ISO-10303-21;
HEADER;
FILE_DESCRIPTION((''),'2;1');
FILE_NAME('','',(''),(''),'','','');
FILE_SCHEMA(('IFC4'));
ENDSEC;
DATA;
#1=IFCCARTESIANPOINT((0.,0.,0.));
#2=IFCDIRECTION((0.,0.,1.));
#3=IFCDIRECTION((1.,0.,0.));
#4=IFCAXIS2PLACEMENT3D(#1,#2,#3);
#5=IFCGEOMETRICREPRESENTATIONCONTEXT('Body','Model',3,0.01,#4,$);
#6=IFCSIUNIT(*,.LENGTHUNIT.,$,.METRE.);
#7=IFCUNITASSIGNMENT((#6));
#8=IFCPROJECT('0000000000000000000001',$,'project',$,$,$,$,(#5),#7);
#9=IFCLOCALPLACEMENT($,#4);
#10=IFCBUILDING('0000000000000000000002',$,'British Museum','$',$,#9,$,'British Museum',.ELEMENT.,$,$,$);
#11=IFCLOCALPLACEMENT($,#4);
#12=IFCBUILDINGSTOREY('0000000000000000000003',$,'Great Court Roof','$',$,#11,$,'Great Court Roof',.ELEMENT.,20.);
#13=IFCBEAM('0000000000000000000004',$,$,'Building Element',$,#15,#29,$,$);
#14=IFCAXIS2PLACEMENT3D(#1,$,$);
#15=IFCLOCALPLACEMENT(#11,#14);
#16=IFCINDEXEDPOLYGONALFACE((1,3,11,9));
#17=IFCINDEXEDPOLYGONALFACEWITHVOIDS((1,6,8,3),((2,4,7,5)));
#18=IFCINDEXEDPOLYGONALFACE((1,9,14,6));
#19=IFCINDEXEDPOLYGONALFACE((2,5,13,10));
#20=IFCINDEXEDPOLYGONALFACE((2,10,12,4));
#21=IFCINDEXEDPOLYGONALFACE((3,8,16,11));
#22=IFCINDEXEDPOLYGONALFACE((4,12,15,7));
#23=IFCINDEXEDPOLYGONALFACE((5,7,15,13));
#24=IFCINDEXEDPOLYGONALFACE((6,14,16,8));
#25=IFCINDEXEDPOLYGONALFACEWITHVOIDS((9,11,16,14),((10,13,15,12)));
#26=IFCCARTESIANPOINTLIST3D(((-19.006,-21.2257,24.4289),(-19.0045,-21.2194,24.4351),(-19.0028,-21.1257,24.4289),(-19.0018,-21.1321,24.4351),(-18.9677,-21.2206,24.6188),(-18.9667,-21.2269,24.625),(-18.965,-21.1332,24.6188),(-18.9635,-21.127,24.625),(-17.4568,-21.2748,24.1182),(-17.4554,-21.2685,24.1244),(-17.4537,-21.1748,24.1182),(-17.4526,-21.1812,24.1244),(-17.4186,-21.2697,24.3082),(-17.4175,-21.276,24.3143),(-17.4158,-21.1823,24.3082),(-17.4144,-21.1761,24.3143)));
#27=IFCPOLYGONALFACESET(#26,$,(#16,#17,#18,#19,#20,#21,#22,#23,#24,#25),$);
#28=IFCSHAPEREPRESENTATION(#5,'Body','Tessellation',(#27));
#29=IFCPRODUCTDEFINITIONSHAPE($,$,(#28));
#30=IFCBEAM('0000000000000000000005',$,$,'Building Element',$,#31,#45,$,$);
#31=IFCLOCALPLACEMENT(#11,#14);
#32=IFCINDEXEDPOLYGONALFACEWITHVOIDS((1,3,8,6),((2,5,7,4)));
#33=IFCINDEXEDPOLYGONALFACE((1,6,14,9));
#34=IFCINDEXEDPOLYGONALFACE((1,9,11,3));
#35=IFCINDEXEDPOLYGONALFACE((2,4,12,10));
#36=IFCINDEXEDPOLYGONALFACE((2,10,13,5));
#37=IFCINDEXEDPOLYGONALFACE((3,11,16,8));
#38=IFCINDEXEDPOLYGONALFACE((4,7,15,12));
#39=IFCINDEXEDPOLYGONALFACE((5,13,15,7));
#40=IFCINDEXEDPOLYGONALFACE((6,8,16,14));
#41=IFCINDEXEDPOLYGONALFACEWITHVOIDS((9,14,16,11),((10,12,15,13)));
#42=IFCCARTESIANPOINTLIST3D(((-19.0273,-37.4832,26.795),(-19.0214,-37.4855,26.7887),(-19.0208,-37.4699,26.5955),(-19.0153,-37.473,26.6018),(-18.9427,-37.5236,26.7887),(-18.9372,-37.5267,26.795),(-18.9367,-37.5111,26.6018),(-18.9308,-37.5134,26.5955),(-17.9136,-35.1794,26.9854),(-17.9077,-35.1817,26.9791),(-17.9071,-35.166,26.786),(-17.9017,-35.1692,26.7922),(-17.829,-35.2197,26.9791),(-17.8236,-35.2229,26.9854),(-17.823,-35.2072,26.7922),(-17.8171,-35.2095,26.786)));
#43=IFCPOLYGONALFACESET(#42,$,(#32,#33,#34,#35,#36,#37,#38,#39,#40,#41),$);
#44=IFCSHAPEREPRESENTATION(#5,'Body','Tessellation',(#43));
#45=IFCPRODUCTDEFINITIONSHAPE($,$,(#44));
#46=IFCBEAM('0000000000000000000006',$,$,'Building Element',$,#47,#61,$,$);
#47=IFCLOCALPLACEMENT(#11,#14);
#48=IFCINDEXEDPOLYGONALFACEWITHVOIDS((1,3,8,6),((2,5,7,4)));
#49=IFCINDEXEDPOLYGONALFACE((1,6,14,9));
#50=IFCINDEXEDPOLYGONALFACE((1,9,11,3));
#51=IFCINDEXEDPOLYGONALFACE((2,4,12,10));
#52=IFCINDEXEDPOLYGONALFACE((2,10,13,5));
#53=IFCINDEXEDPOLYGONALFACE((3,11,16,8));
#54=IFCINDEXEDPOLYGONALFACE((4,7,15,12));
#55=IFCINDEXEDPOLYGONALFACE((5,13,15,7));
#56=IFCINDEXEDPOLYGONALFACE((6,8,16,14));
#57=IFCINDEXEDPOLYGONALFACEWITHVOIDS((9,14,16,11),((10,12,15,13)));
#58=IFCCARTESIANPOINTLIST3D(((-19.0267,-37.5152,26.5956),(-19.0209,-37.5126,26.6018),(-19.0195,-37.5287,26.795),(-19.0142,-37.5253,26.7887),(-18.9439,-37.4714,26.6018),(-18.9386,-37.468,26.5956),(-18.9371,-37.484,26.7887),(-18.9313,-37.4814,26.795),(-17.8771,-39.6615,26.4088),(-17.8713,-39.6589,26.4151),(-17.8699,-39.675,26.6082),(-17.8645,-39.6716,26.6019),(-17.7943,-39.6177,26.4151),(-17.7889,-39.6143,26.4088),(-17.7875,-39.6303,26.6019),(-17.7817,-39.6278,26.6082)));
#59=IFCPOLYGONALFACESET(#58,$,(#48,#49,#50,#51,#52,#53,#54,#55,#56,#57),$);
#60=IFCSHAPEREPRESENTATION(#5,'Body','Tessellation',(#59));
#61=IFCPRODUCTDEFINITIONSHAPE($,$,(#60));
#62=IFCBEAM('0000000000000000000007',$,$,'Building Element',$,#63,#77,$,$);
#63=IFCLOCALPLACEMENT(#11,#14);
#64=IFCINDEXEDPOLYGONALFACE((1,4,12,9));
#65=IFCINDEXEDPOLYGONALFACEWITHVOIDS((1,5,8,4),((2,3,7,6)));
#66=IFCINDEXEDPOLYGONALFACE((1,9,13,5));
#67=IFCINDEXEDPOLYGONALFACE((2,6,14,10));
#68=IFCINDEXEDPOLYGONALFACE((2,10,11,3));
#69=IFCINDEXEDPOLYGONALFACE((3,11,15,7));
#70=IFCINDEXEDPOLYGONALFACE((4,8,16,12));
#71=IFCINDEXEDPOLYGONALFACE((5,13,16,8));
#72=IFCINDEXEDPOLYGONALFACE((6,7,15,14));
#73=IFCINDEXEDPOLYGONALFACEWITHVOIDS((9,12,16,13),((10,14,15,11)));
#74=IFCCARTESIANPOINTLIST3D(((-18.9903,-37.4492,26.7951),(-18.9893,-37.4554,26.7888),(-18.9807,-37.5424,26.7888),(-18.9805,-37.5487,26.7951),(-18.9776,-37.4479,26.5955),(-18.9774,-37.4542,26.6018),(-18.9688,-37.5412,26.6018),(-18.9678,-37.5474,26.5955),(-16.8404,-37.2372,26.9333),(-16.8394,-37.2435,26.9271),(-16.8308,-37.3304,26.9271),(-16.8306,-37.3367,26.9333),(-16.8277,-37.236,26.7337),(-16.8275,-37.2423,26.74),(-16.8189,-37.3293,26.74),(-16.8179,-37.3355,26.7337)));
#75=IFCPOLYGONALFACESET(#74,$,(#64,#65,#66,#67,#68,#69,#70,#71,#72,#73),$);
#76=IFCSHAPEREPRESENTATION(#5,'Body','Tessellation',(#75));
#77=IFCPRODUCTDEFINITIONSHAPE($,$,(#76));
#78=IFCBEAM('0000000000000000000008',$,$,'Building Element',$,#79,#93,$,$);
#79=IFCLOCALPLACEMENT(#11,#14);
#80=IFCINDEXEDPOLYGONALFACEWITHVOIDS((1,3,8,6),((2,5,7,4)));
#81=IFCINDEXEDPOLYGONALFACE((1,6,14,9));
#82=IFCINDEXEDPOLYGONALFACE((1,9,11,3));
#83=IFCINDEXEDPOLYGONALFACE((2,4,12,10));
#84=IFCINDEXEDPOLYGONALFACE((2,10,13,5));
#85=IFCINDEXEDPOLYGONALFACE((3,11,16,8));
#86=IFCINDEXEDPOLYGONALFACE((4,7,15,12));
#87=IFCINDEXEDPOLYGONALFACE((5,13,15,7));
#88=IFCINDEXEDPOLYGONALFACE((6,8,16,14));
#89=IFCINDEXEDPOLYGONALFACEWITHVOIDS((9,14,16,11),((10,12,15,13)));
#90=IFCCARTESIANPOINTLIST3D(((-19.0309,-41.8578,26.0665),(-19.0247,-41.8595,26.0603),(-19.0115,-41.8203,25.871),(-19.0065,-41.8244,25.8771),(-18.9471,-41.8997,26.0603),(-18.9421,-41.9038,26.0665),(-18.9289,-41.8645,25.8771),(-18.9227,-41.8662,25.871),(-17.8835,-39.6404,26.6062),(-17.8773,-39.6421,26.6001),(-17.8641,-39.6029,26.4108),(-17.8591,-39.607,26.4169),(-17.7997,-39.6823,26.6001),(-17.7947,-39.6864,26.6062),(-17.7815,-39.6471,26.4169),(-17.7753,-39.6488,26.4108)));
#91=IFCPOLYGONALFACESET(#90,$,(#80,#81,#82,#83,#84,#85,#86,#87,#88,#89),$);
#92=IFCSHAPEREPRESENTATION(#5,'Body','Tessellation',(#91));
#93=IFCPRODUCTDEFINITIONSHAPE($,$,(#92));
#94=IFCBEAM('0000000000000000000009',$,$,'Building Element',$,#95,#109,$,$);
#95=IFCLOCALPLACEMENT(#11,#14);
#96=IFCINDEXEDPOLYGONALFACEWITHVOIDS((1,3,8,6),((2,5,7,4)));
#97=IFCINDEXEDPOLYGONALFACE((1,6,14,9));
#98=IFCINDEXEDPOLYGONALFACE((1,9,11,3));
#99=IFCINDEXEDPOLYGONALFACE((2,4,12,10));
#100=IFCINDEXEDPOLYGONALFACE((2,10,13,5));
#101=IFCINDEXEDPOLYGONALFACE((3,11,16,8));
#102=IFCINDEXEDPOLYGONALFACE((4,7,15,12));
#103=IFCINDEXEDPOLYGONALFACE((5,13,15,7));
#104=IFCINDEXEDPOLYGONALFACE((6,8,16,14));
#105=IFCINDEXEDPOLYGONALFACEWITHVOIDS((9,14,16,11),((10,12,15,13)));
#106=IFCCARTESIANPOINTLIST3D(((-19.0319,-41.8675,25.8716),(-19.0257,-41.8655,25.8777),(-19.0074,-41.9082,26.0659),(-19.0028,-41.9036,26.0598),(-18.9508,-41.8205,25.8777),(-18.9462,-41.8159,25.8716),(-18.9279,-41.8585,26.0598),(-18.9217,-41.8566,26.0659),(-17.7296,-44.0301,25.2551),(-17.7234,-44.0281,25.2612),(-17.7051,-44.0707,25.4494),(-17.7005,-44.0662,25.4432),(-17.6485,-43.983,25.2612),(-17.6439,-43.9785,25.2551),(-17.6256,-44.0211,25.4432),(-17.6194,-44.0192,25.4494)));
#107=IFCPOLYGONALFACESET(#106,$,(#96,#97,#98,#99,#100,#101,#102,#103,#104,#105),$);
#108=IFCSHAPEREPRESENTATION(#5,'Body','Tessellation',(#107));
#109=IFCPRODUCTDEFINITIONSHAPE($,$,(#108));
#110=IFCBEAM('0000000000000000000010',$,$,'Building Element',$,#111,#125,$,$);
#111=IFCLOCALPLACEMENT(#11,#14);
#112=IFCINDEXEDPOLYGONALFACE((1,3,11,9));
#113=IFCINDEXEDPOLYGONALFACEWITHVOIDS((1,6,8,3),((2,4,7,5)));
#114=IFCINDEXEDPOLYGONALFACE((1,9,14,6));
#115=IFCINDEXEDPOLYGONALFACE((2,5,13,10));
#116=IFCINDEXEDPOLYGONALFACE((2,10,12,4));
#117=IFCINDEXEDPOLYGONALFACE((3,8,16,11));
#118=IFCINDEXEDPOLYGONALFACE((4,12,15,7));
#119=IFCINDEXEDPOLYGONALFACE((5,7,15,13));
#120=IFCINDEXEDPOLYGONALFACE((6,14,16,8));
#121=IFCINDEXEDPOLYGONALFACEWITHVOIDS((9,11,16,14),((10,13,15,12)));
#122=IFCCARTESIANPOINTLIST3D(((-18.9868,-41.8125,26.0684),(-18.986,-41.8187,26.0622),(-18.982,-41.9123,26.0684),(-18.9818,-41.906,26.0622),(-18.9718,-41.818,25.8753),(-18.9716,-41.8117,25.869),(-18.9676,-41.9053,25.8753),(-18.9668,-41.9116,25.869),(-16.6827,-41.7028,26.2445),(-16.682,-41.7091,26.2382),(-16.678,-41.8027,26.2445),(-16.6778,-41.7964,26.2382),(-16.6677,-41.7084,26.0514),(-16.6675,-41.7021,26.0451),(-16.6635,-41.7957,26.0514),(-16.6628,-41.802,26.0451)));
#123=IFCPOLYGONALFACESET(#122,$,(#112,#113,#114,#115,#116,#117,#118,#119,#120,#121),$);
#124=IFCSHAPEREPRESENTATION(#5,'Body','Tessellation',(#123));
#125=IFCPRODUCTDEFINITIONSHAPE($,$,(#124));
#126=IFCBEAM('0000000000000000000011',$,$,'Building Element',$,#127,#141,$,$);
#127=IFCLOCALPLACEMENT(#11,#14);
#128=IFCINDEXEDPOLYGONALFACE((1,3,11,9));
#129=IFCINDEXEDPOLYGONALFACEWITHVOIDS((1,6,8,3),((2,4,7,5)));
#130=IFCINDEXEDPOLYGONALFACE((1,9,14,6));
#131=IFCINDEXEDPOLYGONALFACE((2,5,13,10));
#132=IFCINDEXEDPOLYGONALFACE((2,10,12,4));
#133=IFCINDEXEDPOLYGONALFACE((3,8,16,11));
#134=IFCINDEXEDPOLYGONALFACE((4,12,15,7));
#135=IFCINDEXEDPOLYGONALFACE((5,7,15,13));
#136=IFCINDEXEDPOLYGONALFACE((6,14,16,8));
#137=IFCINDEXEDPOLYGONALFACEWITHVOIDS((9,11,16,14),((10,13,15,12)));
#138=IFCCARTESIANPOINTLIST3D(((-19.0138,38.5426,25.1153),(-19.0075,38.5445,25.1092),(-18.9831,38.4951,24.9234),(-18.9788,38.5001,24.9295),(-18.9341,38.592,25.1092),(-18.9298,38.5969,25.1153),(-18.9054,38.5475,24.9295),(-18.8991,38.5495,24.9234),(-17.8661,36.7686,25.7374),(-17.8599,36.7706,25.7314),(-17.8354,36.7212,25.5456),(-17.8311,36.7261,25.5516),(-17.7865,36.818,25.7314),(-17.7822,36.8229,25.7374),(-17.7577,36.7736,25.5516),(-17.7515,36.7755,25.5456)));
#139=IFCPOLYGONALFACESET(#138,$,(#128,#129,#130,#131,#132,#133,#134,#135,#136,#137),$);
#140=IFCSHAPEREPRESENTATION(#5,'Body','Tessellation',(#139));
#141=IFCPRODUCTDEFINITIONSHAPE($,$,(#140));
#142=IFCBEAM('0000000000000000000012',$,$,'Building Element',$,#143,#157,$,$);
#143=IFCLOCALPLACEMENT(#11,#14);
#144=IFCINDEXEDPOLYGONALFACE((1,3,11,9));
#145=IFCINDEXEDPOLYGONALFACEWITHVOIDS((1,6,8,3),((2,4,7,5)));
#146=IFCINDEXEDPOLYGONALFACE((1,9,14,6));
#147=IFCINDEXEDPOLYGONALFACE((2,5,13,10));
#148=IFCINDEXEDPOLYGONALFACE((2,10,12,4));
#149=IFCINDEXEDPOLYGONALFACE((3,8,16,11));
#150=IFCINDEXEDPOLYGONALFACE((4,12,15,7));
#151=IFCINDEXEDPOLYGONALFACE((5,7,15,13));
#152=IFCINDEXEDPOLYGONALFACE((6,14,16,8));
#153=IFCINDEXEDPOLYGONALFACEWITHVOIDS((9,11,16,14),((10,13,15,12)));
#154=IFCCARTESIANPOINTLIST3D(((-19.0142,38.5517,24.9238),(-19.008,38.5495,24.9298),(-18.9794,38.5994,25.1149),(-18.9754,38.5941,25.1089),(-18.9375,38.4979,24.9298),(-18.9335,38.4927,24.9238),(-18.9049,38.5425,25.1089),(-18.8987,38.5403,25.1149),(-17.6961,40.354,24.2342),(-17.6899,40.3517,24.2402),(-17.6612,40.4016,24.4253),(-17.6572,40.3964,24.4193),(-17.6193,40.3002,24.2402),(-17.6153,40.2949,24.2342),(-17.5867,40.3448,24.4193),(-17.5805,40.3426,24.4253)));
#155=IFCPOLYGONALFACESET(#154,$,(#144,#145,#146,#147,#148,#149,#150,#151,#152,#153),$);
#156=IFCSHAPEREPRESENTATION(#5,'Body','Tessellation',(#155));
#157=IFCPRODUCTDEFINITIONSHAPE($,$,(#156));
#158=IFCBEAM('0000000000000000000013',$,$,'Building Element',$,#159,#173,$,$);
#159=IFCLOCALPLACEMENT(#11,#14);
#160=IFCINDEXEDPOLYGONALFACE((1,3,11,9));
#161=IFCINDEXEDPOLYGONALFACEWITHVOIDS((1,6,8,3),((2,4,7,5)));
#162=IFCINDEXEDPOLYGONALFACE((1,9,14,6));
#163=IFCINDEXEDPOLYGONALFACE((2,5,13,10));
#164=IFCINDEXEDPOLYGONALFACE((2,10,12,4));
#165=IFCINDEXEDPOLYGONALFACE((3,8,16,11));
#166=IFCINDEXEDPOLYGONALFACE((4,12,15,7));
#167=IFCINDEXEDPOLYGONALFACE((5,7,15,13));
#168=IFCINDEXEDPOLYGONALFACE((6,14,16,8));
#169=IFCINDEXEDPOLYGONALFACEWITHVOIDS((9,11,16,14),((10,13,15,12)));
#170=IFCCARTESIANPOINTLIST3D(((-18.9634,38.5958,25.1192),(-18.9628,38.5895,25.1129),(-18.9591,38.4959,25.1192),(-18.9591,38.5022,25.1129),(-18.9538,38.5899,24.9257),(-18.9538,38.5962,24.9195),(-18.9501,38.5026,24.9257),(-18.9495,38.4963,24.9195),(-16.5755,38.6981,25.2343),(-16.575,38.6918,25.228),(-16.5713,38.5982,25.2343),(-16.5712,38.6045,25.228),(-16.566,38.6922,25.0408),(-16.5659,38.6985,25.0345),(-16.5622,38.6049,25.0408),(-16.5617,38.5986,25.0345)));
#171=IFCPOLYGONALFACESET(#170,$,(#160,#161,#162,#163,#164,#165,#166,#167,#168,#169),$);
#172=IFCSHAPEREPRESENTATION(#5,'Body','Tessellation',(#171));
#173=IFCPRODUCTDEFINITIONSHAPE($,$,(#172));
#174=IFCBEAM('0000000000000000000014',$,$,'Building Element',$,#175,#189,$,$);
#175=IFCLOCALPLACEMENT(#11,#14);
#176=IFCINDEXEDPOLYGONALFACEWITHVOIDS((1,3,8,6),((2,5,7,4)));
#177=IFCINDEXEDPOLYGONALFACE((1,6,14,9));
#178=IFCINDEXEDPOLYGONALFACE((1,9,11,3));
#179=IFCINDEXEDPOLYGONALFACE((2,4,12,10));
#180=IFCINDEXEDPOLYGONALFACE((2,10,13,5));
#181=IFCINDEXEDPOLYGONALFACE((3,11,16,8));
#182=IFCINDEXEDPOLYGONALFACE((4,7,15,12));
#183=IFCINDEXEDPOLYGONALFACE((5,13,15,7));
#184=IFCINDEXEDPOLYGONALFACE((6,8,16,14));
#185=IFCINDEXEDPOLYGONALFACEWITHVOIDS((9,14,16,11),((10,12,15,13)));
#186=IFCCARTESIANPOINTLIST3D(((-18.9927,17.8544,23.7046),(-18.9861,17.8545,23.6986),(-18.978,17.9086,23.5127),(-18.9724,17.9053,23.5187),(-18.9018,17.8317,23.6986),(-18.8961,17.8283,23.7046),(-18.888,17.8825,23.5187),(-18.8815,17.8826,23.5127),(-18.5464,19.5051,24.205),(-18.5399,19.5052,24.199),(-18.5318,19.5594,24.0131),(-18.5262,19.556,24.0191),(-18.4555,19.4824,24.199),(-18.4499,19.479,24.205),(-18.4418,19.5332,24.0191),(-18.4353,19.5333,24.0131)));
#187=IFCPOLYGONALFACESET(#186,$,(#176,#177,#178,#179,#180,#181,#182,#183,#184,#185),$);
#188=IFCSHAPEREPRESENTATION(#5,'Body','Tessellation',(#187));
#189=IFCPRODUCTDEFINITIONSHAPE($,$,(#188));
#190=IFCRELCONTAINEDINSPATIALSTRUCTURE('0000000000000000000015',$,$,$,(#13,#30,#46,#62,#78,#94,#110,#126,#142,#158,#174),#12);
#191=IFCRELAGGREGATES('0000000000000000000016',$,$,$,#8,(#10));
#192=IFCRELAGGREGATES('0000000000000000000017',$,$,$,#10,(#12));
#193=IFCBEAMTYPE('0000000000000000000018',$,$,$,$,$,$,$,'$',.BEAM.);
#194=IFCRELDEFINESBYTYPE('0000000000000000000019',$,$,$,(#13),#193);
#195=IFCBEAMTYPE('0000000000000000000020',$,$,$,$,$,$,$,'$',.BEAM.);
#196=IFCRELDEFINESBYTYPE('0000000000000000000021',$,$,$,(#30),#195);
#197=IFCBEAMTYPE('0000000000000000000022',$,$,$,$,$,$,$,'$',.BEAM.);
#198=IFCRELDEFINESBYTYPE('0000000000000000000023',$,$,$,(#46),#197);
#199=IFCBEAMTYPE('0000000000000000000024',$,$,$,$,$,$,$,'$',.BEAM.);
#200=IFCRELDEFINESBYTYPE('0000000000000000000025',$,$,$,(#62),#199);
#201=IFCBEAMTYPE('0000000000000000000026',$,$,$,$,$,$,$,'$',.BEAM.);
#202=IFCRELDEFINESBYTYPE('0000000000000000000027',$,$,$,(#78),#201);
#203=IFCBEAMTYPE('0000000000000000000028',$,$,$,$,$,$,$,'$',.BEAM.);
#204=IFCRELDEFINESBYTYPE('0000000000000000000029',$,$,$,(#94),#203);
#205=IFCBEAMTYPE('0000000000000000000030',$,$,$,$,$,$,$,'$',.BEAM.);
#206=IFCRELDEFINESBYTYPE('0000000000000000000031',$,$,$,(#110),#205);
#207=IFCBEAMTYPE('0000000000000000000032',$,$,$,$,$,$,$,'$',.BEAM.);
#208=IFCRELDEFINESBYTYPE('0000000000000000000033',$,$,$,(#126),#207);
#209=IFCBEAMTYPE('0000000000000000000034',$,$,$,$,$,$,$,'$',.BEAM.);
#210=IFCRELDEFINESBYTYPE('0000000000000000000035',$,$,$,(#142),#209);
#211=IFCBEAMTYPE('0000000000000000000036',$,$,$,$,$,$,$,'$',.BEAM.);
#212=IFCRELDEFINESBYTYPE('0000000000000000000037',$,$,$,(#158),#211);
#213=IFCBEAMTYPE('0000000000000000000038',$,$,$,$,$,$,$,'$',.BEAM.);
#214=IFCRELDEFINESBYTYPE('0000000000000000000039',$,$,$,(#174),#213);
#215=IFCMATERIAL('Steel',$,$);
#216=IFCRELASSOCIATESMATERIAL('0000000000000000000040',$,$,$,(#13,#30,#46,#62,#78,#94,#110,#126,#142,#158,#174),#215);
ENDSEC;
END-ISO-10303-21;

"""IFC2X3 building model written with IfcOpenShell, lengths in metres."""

from ifc_helpers import new_model, si_unit, frame, origin_with_axes, origin_2d, place, context, project, spatial, hollow_rectangle, extrude, material, type_object, element, save


model = new_model("IFC2X3")

# Units and contexts
model_context = context("Model", 3, precision=0.01, world=origin_with_axes(), identifier="Body")
ifc_project = project(units=[si_unit("LENGTHUNIT", "METRE")], contexts=[model_context])

# Building, storey
building_placement = place(None, origin_with_axes())
building = spatial("IfcBuilding", under=ifc_project, at=building_placement, Name="British Museum", Description="$", LongName="British Museum", CompositionType="ELEMENT")
storey_placement = place(None, origin_with_axes())
storey = spatial("IfcBuildingStorey", under=building, at=storey_placement, Name="Great Court Roof", Description="$", LongName="Great Court Roof", CompositionType="ELEMENT", Elevation=20.0)

# Beams
ifc_material = material(Name="Steel")
beam_type_1 = type_object("IfcBeamType", ElementType="$", PredefinedType="BEAM")
beam_1_placement = place(None, origin_with_axes())
element("IfcBeam", 1, at=beam_1_placement, inside=storey, type_object=beam_type_1, material=ifc_material, Description="Building Element", context=model_context, shape_type="SweptSolid", body=[
    extrude(hollow_rectangle(XDim=0.1, YDim=0.2, WallThickness=0.0063, InnerFilletRadius=-0.0063, OuterFilletRadius=0.0, at=origin_2d()), frame((-18.9848, -21.1763, 24.5269), z_axis=(0.980009, -0.031067, -0.196514), x_axis=(0.031685, 0.999498, 0.0)), (0.0, 0.0, 1.0), 1.5808),
])
beam_type_2 = type_object("IfcBeamType", ElementType="$", PredefinedType="BEAM")
beam_2_placement = place(None, origin_with_axes())
element("IfcBeam", 2, at=beam_2_placement, inside=storey, type_object=beam_type_2, material=ifc_material, Description="Building Element", context=model_context, shape_type="SweptSolid", body=[
    extrude(hollow_rectangle(XDim=0.1, YDim=0.2, WallThickness=0.0063, InnerFilletRadius=-0.0063, OuterFilletRadius=0.0, at=origin_2d()), frame((-18.979, -37.4983, 26.6953), z_axis=(0.434019, 0.897842, 0.074209), x_axis=(-0.900325, 0.435219, 0.0)), (0.0, 0.0, 1.0), 2.566),
])
beam_type_3 = type_object("IfcBeamType", ElementType="$", PredefinedType="BEAM")
beam_3_placement = place(None, origin_with_axes())
element("IfcBeam", 3, at=beam_3_placement, inside=storey, type_object=beam_type_3, material=ifc_material, Description="Building Element", context=model_context, shape_type="SweptSolid", body=[
    extrude(hollow_rectangle(XDim=0.1, YDim=0.2, WallThickness=0.0063, InnerFilletRadius=-0.0063, OuterFilletRadius=0.0, at=origin_2d()), frame((-18.979, -37.4983, 26.6953), z_axis=(0.470777, -0.878931, -0.076483), x_axis=(0.881513, 0.47216, 0.0)), (0.0, 0.0, 1.0), 2.442),
])
beam_type_4 = type_object("IfcBeamType", ElementType="$", PredefinedType="BEAM")
beam_4_placement = place(None, origin_with_axes())
element("IfcBeam", 4, at=beam_4_placement, inside=storey, type_object=beam_type_4, material=ifc_material, Description="Building Element", context=model_context, shape_type="SweptSolid", body=[
    extrude(hollow_rectangle(XDim=0.1, YDim=0.2, WallThickness=0.0063, InnerFilletRadius=-0.0063, OuterFilletRadius=0.0, at=origin_2d()), frame((-18.979, -37.4983, 26.6953), z_axis=(0.993143, 0.097908, 0.06388), x_axis=(-0.098108, 0.995176, 0.0)), (0.0, 0.0, 1.0), 2.1647),
])
beam_type_5 = type_object("IfcBeamType", ElementType="$", PredefinedType="BEAM")
beam_5_placement = place(None, origin_with_axes())
element("IfcBeam", 5, at=beam_5_placement, inside=storey, type_object=beam_type_5, material=ifc_material, Description="Building Element", context=model_context, shape_type="SweptSolid", body=[
    extrude(hollow_rectangle(XDim=0.1, YDim=0.2, WallThickness=0.0063, InnerFilletRadius=-0.0063, OuterFilletRadius=0.0, at=origin_2d()), frame((-18.9768, -41.862, 25.9687), z_axis=(0.449187, 0.868089, 0.211311), x_axis=(-0.888144, 0.459565, 0.0)), (0.0, 0.0, 1.0), 2.5544),
])
beam_type_6 = type_object("IfcBeamType", ElementType="$", PredefinedType="BEAM")
beam_6_placement = place(None, origin_with_axes())
element("IfcBeam", 6, at=beam_6_placement, inside=storey, type_object=beam_type_6, material=ifc_material, Description="Building Element", context=model_context, shape_type="SweptSolid", body=[
    extrude(hollow_rectangle(XDim=0.1, YDim=0.2, WallThickness=0.0063, InnerFilletRadius=-0.0063, OuterFilletRadius=0.0, at=origin_2d()), frame((-18.9768, -41.862, 25.9687), z_axis=(0.501147, -0.832206, -0.237244), x_axis=(0.856664, 0.515875, 0.0)), (0.0, 0.0, 1.0), 2.5986),
])
beam_type_7 = type_object("IfcBeamType", ElementType="$", PredefinedType="BEAM")
beam_7_placement = place(None, origin_with_axes())
element("IfcBeam", 7, at=beam_7_placement, inside=storey, type_object=beam_type_7, material=ifc_material, Description="Building Element", context=model_context, shape_type="SweptSolid", body=[
    extrude(hollow_rectangle(XDim=0.1, YDim=0.2, WallThickness=0.0063, InnerFilletRadius=-0.0063, OuterFilletRadius=0.0, at=origin_2d()), frame((-18.9768, -41.862, 25.9687), z_axis=(0.995972, 0.047394, 0.07611), x_axis=(-0.047532, 0.99887, 0.0)), (0.0, 0.0, 1.0), 2.3134),
])
beam_type_8 = type_object("IfcBeamType", ElementType="$", PredefinedType="BEAM")
beam_8_placement = place(None, origin_with_axes())
element("IfcBeam", 8, at=beam_8_placement, inside=storey, type_object=beam_type_8, material=ifc_material, Description="Building Element", context=model_context, shape_type="SweptSolid", body=[
    extrude(hollow_rectangle(XDim=0.1, YDim=0.2, WallThickness=0.0063, InnerFilletRadius=-0.0063, OuterFilletRadius=0.0, at=origin_2d()), frame((-18.9564, 38.546, 25.0193), z_axis=(0.521067, -0.80542, 0.282469), x_axis=(0.839611, 0.543187, 0.0)), (0.0, 0.0, 1.0), 2.2025),
])
beam_type_9 = type_object("IfcBeamType", ElementType="$", PredefinedType="BEAM")
beam_9_placement = place(None, origin_with_axes())
element("IfcBeam", 9, at=beam_9_placement, inside=storey, type_object=beam_type_9, material=ifc_material, Description="Building Element", context=model_context, shape_type="SweptSolid", body=[
    extrude(hollow_rectangle(XDim=0.1, YDim=0.2, WallThickness=0.0063, InnerFilletRadius=-0.0063, OuterFilletRadius=0.0, at=origin_2d()), frame((-18.9564, 38.546, 25.0193), z_axis=(0.564066, 0.771208, -0.295074), x_axis=(-0.807146, 0.590351, 0.0)), (0.0, 0.0, 1.0), 2.3369),
])
beam_type_10 = type_object("IfcBeamType", ElementType="$", PredefinedType="BEAM")
beam_10_placement = place(None, origin_with_axes())
element("IfcBeam", 10, at=beam_10_placement, inside=storey, type_object=beam_type_10, material=ifc_material, Description="Building Element", context=model_context, shape_type="SweptSolid", body=[
    extrude(hollow_rectangle(XDim=0.1, YDim=0.2, WallThickness=0.0063, InnerFilletRadius=-0.0063, OuterFilletRadius=0.0, at=origin_2d()), frame((-18.9564, 38.546, 25.0193), z_axis=(0.997928, 0.042764, 0.048078), x_axis=(-0.042813, 0.999083, 0.0)), (0.0, 0.0, 1.0), 2.3928),
])
beam_type_11 = type_object("IfcBeamType", ElementType="$", PredefinedType="BEAM")
beam_11_placement = place(None, origin_with_axes())
element("IfcBeam", 11, at=beam_11_placement, inside=storey, type_object=beam_type_11, material=ifc_material, Description="Building Element", context=model_context, shape_type="SweptSolid", body=[
    extrude(hollow_rectangle(XDim=0.1, YDim=0.2, WallThickness=0.0063, InnerFilletRadius=-0.0063, OuterFilletRadius=0.0, at=origin_2d()), frame((-18.9371, 17.8685, 23.6086), z_axis=(0.25045, 0.926496, 0.280855), x_axis=(-0.965351, 0.260954, 0.0)), (0.0, 0.0, 1.0), 1.7817),
])

save(model, "model.ifc")
